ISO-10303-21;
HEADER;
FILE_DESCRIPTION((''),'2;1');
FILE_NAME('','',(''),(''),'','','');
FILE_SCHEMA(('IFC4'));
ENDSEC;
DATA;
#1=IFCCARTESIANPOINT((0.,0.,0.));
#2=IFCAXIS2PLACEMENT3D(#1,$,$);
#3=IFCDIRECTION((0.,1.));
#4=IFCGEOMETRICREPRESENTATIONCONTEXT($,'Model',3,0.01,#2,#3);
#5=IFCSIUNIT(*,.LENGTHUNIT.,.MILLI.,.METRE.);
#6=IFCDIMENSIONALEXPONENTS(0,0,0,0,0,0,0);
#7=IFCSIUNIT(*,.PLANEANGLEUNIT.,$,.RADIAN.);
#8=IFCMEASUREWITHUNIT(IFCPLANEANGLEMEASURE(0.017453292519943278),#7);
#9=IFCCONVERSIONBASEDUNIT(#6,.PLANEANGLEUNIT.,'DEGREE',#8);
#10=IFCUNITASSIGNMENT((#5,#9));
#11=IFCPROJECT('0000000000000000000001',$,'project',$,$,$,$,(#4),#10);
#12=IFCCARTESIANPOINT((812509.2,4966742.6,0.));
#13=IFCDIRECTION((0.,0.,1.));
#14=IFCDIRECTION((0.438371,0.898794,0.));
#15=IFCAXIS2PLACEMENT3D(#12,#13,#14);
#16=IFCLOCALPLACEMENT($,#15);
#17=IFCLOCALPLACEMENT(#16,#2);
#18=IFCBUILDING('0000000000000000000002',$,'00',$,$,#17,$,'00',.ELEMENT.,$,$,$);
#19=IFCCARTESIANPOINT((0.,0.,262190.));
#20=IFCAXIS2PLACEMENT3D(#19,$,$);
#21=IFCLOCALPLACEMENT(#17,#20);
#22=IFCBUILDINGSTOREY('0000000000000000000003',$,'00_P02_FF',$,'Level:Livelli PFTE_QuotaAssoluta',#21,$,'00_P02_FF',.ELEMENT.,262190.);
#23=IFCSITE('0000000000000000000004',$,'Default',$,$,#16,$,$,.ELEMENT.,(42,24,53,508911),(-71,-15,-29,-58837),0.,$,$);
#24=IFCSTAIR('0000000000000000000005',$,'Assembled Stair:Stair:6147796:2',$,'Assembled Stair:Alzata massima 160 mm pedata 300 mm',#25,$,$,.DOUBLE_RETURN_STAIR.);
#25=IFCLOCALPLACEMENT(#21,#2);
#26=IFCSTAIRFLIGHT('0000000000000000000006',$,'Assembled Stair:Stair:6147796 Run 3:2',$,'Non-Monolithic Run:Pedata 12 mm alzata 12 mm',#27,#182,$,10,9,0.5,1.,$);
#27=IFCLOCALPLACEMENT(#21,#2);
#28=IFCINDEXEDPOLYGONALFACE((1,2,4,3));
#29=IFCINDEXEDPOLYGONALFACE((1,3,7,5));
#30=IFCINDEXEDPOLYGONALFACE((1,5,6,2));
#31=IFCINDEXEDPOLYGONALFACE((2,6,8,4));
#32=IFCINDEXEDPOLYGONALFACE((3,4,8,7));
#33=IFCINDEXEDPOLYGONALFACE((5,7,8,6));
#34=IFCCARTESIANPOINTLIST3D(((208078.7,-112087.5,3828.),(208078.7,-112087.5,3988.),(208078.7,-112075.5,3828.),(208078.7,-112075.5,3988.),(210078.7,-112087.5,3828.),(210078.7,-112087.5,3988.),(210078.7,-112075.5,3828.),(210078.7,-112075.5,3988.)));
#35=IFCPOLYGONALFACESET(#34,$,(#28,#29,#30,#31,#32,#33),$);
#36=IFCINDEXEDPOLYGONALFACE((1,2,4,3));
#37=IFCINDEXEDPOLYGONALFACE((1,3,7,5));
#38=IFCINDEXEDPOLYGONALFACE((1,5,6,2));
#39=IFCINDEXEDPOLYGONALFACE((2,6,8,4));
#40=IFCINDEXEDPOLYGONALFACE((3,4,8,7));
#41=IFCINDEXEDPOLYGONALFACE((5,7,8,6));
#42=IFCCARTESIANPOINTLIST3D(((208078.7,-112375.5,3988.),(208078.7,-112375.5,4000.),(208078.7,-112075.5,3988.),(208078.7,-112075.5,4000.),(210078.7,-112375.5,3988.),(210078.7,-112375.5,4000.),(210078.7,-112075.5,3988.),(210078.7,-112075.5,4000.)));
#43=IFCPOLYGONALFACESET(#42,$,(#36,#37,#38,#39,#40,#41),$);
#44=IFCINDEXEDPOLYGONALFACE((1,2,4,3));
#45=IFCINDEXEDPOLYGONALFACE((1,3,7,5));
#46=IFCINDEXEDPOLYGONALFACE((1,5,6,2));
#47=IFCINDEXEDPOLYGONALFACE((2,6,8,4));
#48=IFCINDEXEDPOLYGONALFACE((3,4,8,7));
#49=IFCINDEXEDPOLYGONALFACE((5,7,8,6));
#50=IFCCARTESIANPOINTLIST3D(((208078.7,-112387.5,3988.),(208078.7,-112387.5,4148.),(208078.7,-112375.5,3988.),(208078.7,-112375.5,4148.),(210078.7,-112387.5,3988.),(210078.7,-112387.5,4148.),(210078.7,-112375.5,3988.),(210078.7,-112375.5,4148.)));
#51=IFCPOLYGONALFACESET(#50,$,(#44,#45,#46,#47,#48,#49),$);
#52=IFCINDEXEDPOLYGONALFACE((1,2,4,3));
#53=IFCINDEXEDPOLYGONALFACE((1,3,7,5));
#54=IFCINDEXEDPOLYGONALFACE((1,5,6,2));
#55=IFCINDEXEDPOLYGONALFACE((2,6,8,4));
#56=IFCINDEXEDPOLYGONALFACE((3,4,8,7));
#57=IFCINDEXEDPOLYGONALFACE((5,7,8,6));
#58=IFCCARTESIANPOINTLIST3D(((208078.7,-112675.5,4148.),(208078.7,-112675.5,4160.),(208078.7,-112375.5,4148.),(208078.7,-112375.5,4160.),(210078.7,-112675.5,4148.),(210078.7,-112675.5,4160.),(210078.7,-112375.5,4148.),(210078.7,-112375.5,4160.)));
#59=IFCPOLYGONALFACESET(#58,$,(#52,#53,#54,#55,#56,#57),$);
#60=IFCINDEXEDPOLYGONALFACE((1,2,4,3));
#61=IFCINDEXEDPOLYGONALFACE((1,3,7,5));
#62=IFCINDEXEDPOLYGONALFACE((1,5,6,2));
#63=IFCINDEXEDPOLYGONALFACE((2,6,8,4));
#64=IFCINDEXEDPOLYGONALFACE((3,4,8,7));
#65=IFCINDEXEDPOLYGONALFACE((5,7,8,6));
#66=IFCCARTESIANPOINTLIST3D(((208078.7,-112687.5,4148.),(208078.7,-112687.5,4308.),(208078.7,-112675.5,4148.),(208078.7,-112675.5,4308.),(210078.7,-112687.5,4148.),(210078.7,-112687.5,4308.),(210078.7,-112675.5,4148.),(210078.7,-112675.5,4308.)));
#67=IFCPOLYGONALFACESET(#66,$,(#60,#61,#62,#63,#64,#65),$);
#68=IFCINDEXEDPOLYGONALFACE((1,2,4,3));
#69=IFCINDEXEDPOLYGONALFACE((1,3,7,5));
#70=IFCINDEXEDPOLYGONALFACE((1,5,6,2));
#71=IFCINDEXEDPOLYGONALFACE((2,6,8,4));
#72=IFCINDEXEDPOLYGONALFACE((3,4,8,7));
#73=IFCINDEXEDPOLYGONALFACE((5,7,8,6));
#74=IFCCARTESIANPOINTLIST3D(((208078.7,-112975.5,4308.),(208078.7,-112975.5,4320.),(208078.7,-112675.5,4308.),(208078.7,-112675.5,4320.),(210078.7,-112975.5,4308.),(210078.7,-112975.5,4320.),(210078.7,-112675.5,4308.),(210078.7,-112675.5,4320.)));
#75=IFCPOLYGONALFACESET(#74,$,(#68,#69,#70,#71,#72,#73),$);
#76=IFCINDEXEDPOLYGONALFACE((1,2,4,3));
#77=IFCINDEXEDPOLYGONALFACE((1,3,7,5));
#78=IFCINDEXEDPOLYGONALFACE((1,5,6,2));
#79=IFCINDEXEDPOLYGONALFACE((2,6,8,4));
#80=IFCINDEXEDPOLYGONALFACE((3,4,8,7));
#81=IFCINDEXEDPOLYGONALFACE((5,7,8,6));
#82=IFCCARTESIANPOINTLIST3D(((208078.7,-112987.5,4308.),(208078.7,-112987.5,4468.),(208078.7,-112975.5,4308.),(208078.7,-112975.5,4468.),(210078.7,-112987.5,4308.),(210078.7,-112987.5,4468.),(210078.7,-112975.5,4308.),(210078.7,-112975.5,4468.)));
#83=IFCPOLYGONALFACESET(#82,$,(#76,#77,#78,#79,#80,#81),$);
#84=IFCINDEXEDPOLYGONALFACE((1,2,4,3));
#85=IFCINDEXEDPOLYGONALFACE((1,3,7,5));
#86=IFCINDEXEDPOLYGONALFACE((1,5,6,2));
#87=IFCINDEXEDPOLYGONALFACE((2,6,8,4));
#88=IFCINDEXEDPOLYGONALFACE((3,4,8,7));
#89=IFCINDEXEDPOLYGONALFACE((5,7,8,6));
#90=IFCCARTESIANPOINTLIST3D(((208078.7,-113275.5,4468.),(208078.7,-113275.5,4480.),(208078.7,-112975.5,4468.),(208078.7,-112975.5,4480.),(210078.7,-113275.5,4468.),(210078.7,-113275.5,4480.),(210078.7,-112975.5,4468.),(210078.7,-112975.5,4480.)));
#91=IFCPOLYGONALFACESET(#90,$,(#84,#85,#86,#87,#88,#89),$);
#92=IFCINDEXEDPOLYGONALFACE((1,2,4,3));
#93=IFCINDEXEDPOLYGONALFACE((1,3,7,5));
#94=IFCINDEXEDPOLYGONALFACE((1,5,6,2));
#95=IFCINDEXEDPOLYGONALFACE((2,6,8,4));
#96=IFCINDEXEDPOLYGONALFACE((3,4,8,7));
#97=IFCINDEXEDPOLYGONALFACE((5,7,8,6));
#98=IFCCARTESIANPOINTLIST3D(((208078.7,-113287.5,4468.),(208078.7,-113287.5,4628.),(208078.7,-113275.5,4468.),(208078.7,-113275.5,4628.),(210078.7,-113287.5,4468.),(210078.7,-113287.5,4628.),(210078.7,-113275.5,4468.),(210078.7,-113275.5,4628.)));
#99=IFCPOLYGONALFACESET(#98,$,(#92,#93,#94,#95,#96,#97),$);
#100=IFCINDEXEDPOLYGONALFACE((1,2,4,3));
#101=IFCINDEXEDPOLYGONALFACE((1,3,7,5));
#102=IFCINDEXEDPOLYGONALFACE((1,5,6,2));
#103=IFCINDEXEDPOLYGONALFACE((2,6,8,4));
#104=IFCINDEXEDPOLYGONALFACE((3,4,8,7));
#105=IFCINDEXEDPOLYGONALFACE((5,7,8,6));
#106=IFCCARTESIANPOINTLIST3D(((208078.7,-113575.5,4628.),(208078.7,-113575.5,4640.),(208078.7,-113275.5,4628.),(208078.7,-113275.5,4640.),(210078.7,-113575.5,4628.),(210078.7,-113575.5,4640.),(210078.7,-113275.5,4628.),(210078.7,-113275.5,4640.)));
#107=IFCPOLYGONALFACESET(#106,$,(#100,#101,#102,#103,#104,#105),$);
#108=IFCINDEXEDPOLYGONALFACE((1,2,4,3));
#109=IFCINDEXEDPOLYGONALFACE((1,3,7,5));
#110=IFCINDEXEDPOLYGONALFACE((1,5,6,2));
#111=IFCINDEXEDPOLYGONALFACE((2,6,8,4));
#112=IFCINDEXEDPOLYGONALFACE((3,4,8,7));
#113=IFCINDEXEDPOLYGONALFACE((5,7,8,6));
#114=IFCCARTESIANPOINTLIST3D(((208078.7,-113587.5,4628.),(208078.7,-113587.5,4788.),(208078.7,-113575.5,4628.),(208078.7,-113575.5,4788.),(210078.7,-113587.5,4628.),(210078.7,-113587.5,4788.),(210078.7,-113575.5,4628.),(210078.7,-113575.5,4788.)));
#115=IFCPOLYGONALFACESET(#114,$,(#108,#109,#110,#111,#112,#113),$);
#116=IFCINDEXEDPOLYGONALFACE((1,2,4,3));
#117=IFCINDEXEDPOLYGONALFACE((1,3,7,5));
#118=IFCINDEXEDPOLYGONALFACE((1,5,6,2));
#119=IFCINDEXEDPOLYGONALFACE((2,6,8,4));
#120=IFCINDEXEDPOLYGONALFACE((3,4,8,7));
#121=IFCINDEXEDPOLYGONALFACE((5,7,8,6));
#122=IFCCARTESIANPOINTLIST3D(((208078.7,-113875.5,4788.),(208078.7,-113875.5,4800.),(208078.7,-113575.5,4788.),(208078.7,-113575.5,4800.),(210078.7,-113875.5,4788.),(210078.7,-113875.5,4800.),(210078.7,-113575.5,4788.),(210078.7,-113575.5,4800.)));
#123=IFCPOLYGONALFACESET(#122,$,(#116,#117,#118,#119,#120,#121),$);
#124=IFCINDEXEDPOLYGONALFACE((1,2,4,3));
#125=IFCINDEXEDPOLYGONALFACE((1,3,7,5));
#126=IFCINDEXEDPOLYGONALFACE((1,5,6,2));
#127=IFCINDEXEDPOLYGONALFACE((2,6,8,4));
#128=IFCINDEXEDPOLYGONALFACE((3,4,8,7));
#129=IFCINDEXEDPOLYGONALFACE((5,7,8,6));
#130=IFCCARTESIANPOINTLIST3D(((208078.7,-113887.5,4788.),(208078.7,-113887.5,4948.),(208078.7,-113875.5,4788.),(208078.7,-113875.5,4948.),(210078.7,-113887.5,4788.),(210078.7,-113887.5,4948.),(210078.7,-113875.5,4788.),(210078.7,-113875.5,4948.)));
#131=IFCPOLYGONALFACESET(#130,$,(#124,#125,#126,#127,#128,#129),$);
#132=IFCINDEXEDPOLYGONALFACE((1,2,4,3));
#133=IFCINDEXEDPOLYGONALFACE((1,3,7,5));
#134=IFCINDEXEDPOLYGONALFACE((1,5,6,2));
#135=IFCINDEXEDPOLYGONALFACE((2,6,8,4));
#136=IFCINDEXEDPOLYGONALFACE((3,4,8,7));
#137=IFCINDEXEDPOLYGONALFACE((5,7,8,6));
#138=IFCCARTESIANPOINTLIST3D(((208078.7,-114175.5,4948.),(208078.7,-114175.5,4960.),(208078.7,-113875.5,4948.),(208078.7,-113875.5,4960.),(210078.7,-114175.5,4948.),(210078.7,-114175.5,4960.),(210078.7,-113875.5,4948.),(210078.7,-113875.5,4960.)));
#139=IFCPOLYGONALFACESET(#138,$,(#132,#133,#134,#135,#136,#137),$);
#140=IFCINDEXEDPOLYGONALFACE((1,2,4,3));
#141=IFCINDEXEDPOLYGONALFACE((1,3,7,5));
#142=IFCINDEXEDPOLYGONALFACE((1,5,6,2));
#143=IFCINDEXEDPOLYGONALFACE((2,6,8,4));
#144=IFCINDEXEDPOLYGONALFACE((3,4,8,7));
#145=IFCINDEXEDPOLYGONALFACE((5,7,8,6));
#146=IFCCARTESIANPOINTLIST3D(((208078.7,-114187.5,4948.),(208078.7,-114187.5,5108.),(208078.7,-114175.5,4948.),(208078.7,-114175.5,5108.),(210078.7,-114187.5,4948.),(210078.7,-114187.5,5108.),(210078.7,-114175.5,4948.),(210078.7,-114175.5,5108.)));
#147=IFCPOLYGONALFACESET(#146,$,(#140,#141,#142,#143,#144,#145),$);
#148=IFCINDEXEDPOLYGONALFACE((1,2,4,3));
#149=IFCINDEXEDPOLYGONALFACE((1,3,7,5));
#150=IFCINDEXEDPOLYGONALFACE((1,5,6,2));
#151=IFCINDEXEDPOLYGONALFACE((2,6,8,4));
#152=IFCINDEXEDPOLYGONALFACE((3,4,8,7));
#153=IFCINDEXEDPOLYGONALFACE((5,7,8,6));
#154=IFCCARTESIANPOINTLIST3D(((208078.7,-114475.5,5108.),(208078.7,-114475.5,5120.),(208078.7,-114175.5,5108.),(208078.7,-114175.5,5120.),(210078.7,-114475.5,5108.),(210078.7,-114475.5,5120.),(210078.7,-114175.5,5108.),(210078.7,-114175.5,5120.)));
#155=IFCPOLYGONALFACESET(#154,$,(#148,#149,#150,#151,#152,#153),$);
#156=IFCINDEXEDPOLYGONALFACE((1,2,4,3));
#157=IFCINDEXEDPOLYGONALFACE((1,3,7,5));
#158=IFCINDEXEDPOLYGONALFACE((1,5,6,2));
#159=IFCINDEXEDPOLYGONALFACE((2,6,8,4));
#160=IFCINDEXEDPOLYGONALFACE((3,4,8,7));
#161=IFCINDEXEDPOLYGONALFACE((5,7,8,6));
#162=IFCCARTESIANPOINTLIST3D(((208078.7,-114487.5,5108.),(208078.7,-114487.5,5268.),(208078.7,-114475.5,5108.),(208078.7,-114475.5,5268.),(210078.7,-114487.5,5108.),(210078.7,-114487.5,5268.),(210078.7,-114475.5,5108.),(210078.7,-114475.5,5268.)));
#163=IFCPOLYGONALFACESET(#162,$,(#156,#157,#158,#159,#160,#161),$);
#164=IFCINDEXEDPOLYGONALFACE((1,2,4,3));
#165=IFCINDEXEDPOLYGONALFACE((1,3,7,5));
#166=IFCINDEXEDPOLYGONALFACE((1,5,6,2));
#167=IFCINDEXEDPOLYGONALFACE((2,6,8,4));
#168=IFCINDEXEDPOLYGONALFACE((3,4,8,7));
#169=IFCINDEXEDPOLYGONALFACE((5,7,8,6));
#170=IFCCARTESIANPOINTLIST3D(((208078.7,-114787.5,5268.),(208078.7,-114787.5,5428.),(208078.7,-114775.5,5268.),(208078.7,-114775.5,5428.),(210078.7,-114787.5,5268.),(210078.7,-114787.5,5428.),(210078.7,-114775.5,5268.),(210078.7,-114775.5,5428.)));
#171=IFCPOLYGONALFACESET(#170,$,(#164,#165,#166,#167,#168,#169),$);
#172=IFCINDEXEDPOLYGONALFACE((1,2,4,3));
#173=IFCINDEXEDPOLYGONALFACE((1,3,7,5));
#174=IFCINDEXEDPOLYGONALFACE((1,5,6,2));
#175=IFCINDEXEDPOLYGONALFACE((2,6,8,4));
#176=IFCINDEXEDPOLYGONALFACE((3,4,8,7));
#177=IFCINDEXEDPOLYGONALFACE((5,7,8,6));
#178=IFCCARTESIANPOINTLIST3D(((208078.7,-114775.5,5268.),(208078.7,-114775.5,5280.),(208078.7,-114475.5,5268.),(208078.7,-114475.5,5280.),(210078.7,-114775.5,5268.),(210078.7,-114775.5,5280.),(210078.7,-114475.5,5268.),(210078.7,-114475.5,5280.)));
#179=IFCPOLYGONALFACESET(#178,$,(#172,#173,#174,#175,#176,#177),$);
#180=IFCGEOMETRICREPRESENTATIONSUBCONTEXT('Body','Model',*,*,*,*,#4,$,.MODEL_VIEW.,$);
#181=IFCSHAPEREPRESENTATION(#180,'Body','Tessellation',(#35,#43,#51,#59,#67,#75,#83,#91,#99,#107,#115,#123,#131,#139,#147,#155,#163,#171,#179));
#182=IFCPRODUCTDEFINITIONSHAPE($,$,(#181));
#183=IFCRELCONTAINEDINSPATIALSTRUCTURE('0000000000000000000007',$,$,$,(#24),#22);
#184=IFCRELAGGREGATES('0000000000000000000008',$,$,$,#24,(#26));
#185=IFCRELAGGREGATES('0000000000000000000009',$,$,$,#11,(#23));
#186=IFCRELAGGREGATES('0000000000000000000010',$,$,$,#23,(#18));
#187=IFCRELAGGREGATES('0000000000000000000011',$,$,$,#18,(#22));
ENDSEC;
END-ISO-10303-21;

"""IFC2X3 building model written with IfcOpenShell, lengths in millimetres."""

from ifc_helpers import new_model, entity, si_unit, converted_unit, direction, frame, frame_2d, origin, origin_2d_with_axis, place, context, subcontext, project, spatial, rectangle, extrude, element, aggregate, save


model = new_model("IFC2X3")

# Units and contexts
model_context = context("Model", 3, precision=0.01, world=origin(), true_north=direction((0.0, 1.0)))
body_context = subcontext(model_context, "Body", "Model", "MODEL_VIEW")
ifc_project = project(units=[si_unit("LENGTHUNIT", "METRE", prefix="MILLI"), converted_unit("PLANEANGLEUNIT", "DEGREE", entity("IfcPlaneAngleMeasure", 0.017453292519943278), si_unit("PLANEANGLEUNIT", "RADIAN"), dimensions=[0, 0, 0, 0, 0, 0, 0])], contexts=[model_context])

# Site, building, storey
site_placement = place(None, frame((812509.2, 4966742.6, 0.0), z_axis=(0.0, 0.0, 1.0), x_axis=(0.438371, 0.898794, 0.0)))
site = spatial("IfcSite", under=ifc_project, at=site_placement, Name="Default", CompositionType="ELEMENT", RefLatitude=(42, 24, 53, 508911), RefLongitude=(-71, -15, -29, -58837), RefElevation=0.0)
building_placement = place(site_placement, origin())
building = spatial("IfcBuilding", under=site, at=building_placement, Name="00", LongName="00", CompositionType="ELEMENT")
storey_placement = place(building_placement, frame((0.0, 0.0, 262190.0)))
storey = spatial("IfcBuildingStorey", under=building, at=storey_placement, Name="00_P02_FF", ObjectType="Level:Livelli PFTE_QuotaAssoluta", LongName="00_P02_FF", CompositionType="ELEMENT", Elevation=262190.0)

# Stair
stair_1_placement = place(storey_placement, origin())
stair_1 = element("IfcStair", 1, at=stair_1_placement, inside=storey, Name="Assembled Stair:Stair:6147796:2", ObjectType="Assembled Stair:Alzata massima 160 mm pedata 300 mm", ShapeType="DOUBLE_RETURN_STAIR")

# Stair flight
stair_flight_1_placement = place(stair_1_placement, origin())
stair_flight_1 = element("IfcStairFlight", 2, at=stair_flight_1_placement, Name="Assembled Stair:Stair:6147796 Run 3:2", ObjectType="Non-Monolithic Run:Pedata 12 mm alzata 12 mm", NumberOfRiser=10, NumberOfTreads=9, RiserHeight=0.5, TreadLength=1.0, context=body_context, shape_type="SweptSolid", body=[
    extrude(rectangle(XDim=2000.0, YDim=12.0, at=origin_2d_with_axis()), frame((209078.7, -112081.5, 3828.0)), (0.0, 0.0, 1.0), 160.0),
    extrude(rectangle(XDim=300.0, YDim=2000.0, at=origin_2d_with_axis()), frame((209078.7, -112225.5, 3988.0), z_axis=(0.0, 0.0, 1.0), x_axis=(0.0, 1.0, 0.0)), (0.0, 0.0, 1.0), 12.0),
    extrude(rectangle(XDim=2000.0, YDim=12.0, at=origin_2d_with_axis()), frame((209078.7, -112381.5, 3988.0)), (0.0, 0.0, 1.0), 160.0),
    extrude(rectangle(XDim=300.0, YDim=2000.0, at=frame_2d((0.0, 0.0), x_axis=(1.0, 0.0))), frame((209078.7, -112525.5, 4148.0), z_axis=(0.0, 0.0, 1.0), x_axis=(0.0, 1.0, 0.0)), (0.0, 0.0, 1.0), 12.0),
    extrude(rectangle(XDim=2000.0, YDim=12.0, at=frame_2d((0.0, 0.0), x_axis=(1.0, 0.0))), frame((209078.7, -112681.5, 4148.0)), (0.0, 0.0, 1.0), 160.0),
    extrude(rectangle(XDim=300.0, YDim=2000.0, at=frame_2d((0.0, 0.0), x_axis=(1.0, 0.0))), frame((209078.7, -112825.5, 4308.0), z_axis=(0.0, 0.0, 1.0), x_axis=(0.0, 1.0, 0.0)), (0.0, 0.0, 1.0), 12.0),
    extrude(rectangle(XDim=2000.0, YDim=12.0, at=frame_2d((0.0, 0.0), x_axis=(1.0, 0.0))), frame((209078.7, -112981.5, 4308.0)), (0.0, 0.0, 1.0), 160.0),
    extrude(rectangle(XDim=300.0, YDim=2000.0, at=frame_2d((0.0, 0.0), x_axis=(1.0, 0.0))), frame((209078.7, -113125.5, 4468.0), z_axis=(0.0, 0.0, 1.0), x_axis=(0.0, 1.0, 0.0)), (0.0, 0.0, 1.0), 12.0),
    extrude(rectangle(XDim=2000.0, YDim=12.0, at=frame_2d((0.0, 0.0), x_axis=(1.0, 0.0))), frame((209078.7, -113281.5, 4468.0)), (0.0, 0.0, 1.0), 160.0),
    extrude(rectangle(XDim=300.0, YDim=2000.0, at=frame_2d((0.0, 0.0), x_axis=(1.0, 0.0))), frame((209078.7, -113425.5, 4628.0), z_axis=(0.0, 0.0, 1.0), x_axis=(0.0, 1.0, 0.0)), (0.0, 0.0, 1.0), 12.0),
    extrude(rectangle(XDim=2000.0, YDim=12.0, at=frame_2d((0.0, 0.0), x_axis=(1.0, 0.0))), frame((209078.7, -113581.5, 4628.0)), (0.0, 0.0, 1.0), 160.0),
    extrude(rectangle(XDim=300.0, YDim=2000.0, at=frame_2d((0.0, 0.0), x_axis=(1.0, 0.0))), frame((209078.7, -113725.5, 4788.0), z_axis=(0.0, 0.0, 1.0), x_axis=(0.0, 1.0, 0.0)), (0.0, 0.0, 1.0), 12.0),
    extrude(rectangle(XDim=2000.0, YDim=12.0, at=origin_2d_with_axis()), frame((209078.7, -113881.5, 4788.0)), (0.0, 0.0, 1.0), 160.0),
    extrude(rectangle(XDim=300.0, YDim=2000.0, at=frame_2d((0.0, 0.0), x_axis=(1.0, 0.0))), frame((209078.7, -114025.5, 4948.0), z_axis=(0.0, 0.0, 1.0), x_axis=(0.0, 1.0, 0.0)), (0.0, 0.0, 1.0), 12.0),
    extrude(rectangle(XDim=2000.0, YDim=12.0, at=origin_2d_with_axis()), frame((209078.7, -114181.5, 4948.0)), (0.0, 0.0, 1.0), 160.0),
    extrude(rectangle(XDim=300.0, YDim=2000.0, at=frame_2d((0.0, 0.0), x_axis=(1.0, 0.0))), frame((209078.7, -114325.5, 5108.0), z_axis=(0.0, 0.0, 1.0), x_axis=(0.0, 1.0, 0.0)), (0.0, 0.0, 1.0), 12.0),
    extrude(rectangle(XDim=2000.0, YDim=12.0, at=origin_2d_with_axis()), frame((209078.7, -114481.5, 5108.0)), (0.0, 0.0, 1.0), 160.0),
    extrude(rectangle(XDim=2000.0, YDim=12.0, at=origin_2d_with_axis()), frame((209078.7, -114781.5, 5268.0)), (0.0, 0.0, 1.0), 160.0),
    extrude(rectangle(XDim=300.0, YDim=2000.0, at=frame_2d((0.0, 0.0), x_axis=(1.0, 0.0))), frame((209078.7, -114625.5, 5268.0), z_axis=(0.0, 0.0, 1.0), x_axis=(0.0, 1.0, 0.0)), (0.0, 0.0, 1.0), 12.0),
])
aggregate(stair_1, [stair_flight_1])

save(model, "model.ifc")
